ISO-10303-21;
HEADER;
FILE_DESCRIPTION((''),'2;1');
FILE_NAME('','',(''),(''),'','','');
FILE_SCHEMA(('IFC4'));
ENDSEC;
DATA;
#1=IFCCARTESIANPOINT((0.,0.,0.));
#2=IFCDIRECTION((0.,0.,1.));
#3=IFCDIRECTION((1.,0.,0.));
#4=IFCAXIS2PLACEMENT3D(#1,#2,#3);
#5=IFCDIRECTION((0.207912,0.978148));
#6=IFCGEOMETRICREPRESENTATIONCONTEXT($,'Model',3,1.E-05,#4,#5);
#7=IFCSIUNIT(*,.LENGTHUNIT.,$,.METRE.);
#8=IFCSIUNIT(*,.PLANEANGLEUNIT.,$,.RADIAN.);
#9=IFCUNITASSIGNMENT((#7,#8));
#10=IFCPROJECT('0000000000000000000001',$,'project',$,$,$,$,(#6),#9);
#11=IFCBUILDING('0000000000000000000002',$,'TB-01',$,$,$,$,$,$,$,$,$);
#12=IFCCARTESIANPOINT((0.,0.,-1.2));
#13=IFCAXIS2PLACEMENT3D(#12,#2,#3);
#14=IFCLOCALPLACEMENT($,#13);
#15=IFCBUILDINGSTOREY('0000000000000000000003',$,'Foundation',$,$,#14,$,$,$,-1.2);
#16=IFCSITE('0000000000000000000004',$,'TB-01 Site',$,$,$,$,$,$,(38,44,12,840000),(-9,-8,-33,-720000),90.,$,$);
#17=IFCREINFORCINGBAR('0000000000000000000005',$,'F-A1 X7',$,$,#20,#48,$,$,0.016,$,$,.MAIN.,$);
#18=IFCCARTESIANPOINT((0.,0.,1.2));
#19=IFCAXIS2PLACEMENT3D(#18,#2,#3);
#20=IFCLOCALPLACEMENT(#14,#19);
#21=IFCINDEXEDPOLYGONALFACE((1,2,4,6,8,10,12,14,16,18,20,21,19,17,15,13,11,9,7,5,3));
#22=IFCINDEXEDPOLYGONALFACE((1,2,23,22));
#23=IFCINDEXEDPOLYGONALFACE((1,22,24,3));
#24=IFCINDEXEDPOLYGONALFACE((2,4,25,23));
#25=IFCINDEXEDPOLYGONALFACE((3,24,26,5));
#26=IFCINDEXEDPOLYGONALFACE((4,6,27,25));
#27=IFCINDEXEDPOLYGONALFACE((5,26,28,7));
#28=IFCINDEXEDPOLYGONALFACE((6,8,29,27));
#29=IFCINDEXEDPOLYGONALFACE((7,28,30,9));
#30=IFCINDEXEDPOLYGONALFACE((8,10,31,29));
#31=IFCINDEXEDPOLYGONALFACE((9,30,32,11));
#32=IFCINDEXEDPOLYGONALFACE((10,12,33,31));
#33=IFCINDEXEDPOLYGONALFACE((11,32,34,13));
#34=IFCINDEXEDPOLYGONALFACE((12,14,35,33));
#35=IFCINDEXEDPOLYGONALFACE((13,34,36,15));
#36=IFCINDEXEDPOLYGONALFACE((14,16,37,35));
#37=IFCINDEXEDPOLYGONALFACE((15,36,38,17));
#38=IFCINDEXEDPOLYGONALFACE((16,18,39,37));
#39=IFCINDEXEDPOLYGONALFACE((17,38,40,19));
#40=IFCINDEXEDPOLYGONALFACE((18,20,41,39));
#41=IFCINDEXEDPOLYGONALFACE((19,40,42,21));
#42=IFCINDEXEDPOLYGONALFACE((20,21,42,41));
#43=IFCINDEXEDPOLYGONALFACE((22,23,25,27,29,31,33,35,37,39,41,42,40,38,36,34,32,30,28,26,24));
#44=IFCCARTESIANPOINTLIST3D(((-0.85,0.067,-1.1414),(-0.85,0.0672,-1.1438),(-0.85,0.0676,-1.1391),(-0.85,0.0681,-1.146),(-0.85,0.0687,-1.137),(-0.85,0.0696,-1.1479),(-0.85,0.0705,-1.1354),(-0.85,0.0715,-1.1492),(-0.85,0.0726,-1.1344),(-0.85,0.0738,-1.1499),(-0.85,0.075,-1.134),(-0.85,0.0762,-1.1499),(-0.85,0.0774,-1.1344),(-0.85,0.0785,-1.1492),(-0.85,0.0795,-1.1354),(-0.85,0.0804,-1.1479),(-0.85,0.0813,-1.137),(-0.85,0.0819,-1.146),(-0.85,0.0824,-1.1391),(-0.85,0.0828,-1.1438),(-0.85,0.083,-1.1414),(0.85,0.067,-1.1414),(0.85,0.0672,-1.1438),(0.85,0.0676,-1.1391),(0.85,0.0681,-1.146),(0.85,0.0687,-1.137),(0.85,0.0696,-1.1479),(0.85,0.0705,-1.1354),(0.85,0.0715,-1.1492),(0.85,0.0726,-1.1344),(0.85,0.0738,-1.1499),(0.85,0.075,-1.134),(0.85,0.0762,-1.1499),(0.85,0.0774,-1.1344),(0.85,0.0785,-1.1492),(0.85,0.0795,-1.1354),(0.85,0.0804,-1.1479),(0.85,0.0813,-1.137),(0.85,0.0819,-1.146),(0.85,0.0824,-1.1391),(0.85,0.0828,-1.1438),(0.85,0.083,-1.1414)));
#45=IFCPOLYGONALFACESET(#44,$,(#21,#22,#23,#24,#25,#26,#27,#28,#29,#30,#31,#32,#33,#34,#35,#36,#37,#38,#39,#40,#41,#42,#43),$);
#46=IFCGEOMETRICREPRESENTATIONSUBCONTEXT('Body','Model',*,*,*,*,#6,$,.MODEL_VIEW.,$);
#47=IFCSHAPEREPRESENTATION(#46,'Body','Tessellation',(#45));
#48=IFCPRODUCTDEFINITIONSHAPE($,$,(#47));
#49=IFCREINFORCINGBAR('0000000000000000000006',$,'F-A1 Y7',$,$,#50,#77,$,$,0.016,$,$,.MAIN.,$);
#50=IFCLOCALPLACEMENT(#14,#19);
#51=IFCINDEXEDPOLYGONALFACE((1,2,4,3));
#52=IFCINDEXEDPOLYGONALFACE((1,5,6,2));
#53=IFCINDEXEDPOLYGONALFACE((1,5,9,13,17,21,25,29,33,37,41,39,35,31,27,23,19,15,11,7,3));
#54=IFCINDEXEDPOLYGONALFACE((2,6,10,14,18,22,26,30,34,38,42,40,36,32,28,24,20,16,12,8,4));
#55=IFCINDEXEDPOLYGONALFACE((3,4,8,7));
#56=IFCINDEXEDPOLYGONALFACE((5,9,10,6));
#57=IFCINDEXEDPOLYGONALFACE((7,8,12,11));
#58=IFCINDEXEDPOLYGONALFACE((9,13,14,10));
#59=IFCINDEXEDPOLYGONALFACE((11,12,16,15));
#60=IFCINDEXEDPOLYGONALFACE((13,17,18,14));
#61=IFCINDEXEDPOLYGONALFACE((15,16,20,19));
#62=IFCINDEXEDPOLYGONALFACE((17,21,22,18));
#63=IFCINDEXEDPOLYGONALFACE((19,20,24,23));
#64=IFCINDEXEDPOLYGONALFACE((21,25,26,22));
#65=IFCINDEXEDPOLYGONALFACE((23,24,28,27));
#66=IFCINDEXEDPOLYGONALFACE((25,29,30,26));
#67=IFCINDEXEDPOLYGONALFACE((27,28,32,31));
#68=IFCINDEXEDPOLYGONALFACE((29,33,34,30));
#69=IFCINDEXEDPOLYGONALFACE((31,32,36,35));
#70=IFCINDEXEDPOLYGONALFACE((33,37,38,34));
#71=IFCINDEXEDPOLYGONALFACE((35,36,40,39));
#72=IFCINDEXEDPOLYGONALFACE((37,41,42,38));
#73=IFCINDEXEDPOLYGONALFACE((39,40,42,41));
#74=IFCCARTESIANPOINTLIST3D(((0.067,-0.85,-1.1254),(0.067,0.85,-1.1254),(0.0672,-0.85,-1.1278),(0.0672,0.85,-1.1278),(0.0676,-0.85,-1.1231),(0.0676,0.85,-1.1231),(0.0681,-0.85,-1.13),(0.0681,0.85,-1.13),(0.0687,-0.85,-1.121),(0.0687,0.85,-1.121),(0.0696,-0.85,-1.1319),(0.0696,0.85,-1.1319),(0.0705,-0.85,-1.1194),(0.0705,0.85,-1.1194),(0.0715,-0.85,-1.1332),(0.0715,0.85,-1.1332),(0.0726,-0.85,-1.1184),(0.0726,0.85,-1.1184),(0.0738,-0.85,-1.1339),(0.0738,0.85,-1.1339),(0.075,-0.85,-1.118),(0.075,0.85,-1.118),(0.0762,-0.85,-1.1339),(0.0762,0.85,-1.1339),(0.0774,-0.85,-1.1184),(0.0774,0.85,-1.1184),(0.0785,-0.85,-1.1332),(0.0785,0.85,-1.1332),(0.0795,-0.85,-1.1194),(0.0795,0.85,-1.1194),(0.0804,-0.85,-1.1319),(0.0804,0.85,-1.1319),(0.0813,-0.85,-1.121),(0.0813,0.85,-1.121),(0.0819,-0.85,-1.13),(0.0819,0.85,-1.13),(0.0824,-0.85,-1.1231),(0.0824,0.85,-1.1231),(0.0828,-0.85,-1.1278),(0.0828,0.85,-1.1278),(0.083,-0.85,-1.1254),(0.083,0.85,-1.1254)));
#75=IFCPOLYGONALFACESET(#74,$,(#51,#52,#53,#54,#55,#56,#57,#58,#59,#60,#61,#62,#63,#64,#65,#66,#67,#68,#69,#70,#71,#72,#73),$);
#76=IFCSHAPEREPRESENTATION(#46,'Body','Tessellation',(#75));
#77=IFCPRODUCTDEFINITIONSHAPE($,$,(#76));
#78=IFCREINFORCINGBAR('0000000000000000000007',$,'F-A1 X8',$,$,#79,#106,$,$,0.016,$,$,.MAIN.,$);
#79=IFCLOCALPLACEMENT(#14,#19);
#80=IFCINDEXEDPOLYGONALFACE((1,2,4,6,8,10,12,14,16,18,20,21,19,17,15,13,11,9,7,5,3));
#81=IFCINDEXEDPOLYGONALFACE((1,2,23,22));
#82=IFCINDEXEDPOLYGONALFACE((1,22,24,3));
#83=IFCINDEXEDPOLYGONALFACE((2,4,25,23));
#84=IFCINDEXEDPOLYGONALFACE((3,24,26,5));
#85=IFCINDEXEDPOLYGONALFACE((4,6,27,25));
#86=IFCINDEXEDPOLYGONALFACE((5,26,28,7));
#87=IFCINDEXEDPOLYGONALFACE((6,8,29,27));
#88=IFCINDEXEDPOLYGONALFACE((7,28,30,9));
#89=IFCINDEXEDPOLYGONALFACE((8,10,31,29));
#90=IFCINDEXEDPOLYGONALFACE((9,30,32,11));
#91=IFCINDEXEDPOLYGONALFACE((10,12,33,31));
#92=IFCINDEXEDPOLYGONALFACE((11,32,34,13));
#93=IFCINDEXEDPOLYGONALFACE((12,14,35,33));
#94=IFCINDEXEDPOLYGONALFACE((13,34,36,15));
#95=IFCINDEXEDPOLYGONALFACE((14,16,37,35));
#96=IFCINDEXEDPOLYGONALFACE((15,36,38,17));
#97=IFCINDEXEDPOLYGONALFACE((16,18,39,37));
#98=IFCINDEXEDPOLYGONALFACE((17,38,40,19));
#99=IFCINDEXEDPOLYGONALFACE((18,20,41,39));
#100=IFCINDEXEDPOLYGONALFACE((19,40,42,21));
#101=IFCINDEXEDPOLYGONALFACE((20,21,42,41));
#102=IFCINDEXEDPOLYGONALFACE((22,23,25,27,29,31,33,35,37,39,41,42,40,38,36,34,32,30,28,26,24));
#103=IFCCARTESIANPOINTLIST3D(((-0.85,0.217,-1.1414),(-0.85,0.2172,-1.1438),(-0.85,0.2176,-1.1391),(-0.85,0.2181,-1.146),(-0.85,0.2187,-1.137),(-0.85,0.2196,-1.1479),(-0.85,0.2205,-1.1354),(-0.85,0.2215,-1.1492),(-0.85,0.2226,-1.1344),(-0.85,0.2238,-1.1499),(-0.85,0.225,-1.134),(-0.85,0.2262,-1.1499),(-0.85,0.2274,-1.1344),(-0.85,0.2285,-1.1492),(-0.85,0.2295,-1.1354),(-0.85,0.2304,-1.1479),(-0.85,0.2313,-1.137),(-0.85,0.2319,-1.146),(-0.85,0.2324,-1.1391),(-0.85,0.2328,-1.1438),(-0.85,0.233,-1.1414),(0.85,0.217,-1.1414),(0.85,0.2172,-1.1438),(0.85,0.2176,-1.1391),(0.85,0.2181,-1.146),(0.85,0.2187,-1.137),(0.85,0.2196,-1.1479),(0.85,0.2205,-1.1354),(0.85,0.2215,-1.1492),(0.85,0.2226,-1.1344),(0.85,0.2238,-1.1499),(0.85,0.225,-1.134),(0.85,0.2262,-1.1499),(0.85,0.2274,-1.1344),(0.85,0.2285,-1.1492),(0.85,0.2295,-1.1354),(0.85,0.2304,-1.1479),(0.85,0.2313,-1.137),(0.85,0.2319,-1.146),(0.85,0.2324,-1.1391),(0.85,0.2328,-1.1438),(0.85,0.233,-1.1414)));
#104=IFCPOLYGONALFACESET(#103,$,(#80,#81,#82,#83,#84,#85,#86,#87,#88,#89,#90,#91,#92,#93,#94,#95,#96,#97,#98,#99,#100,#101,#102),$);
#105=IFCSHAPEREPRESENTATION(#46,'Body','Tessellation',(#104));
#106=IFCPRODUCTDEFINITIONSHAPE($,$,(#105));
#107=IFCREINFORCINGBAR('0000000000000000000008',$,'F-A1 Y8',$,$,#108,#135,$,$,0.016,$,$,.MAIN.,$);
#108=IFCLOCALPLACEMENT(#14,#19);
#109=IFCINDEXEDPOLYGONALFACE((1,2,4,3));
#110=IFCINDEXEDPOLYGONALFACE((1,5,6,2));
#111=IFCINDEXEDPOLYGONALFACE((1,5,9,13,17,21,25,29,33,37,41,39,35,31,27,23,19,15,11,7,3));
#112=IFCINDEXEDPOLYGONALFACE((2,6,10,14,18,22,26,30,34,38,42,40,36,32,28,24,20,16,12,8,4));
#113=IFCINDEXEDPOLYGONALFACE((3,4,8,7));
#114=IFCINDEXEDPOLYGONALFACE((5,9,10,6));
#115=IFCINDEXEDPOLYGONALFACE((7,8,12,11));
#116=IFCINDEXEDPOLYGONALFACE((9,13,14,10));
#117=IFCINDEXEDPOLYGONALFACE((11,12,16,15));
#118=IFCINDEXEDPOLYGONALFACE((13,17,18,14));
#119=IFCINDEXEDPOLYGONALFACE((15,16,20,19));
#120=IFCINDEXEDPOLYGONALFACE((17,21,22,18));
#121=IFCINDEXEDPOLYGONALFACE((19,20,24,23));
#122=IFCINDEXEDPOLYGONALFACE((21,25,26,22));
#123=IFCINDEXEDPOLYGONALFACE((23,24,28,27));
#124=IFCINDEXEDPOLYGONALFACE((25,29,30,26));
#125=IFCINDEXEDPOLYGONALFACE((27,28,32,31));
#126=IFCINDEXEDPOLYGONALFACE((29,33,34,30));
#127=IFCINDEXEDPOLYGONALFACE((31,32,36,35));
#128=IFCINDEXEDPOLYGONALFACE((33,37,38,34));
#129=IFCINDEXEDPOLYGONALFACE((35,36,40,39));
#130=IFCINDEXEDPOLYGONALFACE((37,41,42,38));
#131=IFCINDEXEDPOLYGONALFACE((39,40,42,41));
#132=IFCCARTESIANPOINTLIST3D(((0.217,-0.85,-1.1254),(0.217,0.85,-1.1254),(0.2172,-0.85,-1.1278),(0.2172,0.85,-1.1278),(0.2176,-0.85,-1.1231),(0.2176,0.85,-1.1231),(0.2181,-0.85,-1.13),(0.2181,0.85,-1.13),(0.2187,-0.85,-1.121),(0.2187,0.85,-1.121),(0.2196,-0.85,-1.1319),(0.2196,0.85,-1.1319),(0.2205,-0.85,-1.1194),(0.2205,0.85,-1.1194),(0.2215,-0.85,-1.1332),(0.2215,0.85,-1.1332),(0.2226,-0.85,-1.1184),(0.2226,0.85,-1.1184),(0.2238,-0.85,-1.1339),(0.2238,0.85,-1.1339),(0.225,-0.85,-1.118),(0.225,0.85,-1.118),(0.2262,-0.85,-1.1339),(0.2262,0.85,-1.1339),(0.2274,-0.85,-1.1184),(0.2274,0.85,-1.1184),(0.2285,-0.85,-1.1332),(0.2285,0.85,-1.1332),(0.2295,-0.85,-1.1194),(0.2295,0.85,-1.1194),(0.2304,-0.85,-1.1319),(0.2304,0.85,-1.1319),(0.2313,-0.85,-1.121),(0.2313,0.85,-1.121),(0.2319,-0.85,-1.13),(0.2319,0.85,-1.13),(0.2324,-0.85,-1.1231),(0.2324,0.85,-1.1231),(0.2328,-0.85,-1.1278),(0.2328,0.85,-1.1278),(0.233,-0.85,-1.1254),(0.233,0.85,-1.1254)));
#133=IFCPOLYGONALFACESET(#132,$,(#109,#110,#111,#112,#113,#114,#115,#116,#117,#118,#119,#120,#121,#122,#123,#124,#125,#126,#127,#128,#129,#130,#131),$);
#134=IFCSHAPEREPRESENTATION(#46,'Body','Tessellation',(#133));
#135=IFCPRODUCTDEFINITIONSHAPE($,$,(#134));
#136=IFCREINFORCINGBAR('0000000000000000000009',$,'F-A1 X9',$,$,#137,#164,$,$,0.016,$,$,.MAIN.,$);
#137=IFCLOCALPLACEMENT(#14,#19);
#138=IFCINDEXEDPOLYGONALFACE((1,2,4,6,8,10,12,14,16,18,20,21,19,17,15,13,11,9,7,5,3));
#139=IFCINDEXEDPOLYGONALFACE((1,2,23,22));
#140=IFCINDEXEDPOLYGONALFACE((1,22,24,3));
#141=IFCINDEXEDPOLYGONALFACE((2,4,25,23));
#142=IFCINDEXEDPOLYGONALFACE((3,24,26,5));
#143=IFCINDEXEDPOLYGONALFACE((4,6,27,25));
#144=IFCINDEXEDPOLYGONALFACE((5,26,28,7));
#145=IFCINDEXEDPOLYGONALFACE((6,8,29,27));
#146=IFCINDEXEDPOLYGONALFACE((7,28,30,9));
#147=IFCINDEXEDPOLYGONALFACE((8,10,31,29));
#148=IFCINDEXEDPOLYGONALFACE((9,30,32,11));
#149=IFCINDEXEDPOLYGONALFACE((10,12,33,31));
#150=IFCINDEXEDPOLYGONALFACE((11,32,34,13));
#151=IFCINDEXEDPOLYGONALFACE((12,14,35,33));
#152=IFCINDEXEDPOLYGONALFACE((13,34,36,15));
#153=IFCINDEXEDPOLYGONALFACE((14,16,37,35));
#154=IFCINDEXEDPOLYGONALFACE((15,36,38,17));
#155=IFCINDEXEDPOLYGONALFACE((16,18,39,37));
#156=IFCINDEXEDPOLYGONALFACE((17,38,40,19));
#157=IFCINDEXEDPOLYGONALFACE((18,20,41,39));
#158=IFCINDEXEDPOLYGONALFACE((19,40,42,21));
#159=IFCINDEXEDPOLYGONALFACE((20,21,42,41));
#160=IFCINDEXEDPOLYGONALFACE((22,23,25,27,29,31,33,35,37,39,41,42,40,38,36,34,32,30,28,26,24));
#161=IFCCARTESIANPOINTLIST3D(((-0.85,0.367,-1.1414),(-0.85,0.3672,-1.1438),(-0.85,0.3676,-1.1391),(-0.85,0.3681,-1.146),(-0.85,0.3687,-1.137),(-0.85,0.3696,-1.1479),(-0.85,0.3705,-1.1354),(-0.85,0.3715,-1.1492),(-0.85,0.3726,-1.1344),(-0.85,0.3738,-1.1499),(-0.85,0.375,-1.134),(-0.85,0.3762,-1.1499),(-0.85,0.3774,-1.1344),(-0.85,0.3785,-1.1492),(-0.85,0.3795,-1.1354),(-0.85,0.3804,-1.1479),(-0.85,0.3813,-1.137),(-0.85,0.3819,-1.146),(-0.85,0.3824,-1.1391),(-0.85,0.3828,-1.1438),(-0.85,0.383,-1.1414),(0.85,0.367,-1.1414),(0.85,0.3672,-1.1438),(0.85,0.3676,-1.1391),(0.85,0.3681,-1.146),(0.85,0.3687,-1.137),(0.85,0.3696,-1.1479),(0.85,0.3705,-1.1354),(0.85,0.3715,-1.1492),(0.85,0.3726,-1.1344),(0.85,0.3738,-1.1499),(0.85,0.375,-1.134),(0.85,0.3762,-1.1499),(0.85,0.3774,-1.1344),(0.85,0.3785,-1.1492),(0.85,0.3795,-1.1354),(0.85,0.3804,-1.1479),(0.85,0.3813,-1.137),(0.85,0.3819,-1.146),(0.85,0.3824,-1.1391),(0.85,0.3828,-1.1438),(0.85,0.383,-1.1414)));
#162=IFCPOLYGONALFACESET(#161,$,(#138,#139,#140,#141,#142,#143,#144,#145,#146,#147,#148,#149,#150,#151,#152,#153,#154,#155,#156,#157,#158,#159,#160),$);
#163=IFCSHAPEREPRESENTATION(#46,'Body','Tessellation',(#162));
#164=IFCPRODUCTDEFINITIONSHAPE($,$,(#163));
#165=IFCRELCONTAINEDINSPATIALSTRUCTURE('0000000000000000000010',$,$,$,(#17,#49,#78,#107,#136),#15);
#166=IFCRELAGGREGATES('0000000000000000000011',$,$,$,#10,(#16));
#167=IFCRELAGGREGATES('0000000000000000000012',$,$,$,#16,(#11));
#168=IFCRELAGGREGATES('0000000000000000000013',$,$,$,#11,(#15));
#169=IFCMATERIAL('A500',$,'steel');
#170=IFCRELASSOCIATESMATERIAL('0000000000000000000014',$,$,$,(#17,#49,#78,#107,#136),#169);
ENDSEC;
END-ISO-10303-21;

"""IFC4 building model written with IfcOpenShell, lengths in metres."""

from ifc_helpers import new_model, entity, si_unit, direction, frame, origin_with_axes, place, context, subcontext, project, spatial, material, element, save


model = new_model("IFC4")

# Units and contexts
model_context = context("Model", 3, precision=1e-05, world=origin_with_axes(), true_north=direction((0.207912, 0.978148)))
body_context = subcontext(model_context, "Body", "Model", "MODEL_VIEW")
ifc_project = project(units=[si_unit("LENGTHUNIT", "METRE"), si_unit("PLANEANGLEUNIT", "RADIAN")], contexts=[model_context])

# Site, building, storey
site = spatial("IfcSite", under=ifc_project, Name="TB-01 Site", RefLatitude=(38, 44, 12, 840000), RefLongitude=(-9, -8, -33, -720000), RefElevation=90.0)
building = spatial("IfcBuilding", under=site, Name="TB-01")
storey_placement = place(None, frame((0.0, 0.0, -1.2), z_axis=(0.0, 0.0, 1.0), x_axis=(1.0, 0.0, 0.0)))
storey = spatial("IfcBuildingStorey", under=building, at=storey_placement, Name="Foundation", Elevation=-1.2)

# Reinforcing bars
ifc_material_1 = material(Name="A500", Category="steel")
reinforcing_bar_1_placement = place(storey_placement, frame((0.0, 0.0, 1.2), z_axis=(0.0, 0.0, 1.0), x_axis=(1.0, 0.0, 0.0)))
element("IfcReinforcingBar", 1, at=reinforcing_bar_1_placement, inside=storey, material=ifc_material_1, Name="F-A1 X7", NominalDiameter=0.016, PredefinedType="MAIN", context=body_context, shape_type="AdvancedSweptSolid", body=[
    entity("IfcSweptDiskSolid", entity("IfcPolyline", [entity("IfcCartesianPoint", [-0.85, 0.075, -1.142]), entity("IfcCartesianPoint", [0.85, 0.075, -1.142])]), 0.008),
])
reinforcing_bar_2_placement = place(storey_placement, frame((0.0, 0.0, 1.2), z_axis=(0.0, 0.0, 1.0), x_axis=(1.0, 0.0, 0.0)))
element("IfcReinforcingBar", 2, at=reinforcing_bar_2_placement, inside=storey, material=ifc_material_1, Name="F-A1 Y7", NominalDiameter=0.016, PredefinedType="MAIN", context=body_context, shape_type="AdvancedSweptSolid", body=[
    entity("IfcSweptDiskSolid", entity("IfcPolyline", [entity("IfcCartesianPoint", [0.075, -0.85, -1.126]), entity("IfcCartesianPoint", [0.075, 0.85, -1.126])]), 0.008),
])
reinforcing_bar_3_placement = place(storey_placement, frame((0.0, 0.0, 1.2), z_axis=(0.0, 0.0, 1.0), x_axis=(1.0, 0.0, 0.0)))
element("IfcReinforcingBar", 3, at=reinforcing_bar_3_placement, inside=storey, material=ifc_material_1, Name="F-A1 X8", NominalDiameter=0.016, PredefinedType="MAIN", context=body_context, shape_type="AdvancedSweptSolid", body=[
    entity("IfcSweptDiskSolid", entity("IfcPolyline", [entity("IfcCartesianPoint", [-0.85, 0.225, -1.142]), entity("IfcCartesianPoint", [0.85, 0.225, -1.142])]), 0.008),
])
reinforcing_bar_4_placement = place(storey_placement, frame((0.0, 0.0, 1.2), z_axis=(0.0, 0.0, 1.0), x_axis=(1.0, 0.0, 0.0)))
element("IfcReinforcingBar", 4, at=reinforcing_bar_4_placement, inside=storey, material=ifc_material_1, Name="F-A1 Y8", NominalDiameter=0.016, PredefinedType="MAIN", context=body_context, shape_type="AdvancedSweptSolid", body=[
    entity("IfcSweptDiskSolid", entity("IfcPolyline", [entity("IfcCartesianPoint", [0.225, -0.85, -1.126]), entity("IfcCartesianPoint", [0.225, 0.85, -1.126])]), 0.008),
])
reinforcing_bar_5_placement = place(storey_placement, frame((0.0, 0.0, 1.2), z_axis=(0.0, 0.0, 1.0), x_axis=(1.0, 0.0, 0.0)))
element("IfcReinforcingBar", 5, at=reinforcing_bar_5_placement, inside=storey, material=ifc_material_1, Name="F-A1 X9", NominalDiameter=0.016, PredefinedType="MAIN", context=body_context, shape_type="AdvancedSweptSolid", body=[
    entity("IfcSweptDiskSolid", entity("IfcPolyline", [entity("IfcCartesianPoint", [-0.85, 0.375, -1.142]), entity("IfcCartesianPoint", [0.85, 0.375, -1.142])]), 0.008),
])

save(model, "model.ifc")
